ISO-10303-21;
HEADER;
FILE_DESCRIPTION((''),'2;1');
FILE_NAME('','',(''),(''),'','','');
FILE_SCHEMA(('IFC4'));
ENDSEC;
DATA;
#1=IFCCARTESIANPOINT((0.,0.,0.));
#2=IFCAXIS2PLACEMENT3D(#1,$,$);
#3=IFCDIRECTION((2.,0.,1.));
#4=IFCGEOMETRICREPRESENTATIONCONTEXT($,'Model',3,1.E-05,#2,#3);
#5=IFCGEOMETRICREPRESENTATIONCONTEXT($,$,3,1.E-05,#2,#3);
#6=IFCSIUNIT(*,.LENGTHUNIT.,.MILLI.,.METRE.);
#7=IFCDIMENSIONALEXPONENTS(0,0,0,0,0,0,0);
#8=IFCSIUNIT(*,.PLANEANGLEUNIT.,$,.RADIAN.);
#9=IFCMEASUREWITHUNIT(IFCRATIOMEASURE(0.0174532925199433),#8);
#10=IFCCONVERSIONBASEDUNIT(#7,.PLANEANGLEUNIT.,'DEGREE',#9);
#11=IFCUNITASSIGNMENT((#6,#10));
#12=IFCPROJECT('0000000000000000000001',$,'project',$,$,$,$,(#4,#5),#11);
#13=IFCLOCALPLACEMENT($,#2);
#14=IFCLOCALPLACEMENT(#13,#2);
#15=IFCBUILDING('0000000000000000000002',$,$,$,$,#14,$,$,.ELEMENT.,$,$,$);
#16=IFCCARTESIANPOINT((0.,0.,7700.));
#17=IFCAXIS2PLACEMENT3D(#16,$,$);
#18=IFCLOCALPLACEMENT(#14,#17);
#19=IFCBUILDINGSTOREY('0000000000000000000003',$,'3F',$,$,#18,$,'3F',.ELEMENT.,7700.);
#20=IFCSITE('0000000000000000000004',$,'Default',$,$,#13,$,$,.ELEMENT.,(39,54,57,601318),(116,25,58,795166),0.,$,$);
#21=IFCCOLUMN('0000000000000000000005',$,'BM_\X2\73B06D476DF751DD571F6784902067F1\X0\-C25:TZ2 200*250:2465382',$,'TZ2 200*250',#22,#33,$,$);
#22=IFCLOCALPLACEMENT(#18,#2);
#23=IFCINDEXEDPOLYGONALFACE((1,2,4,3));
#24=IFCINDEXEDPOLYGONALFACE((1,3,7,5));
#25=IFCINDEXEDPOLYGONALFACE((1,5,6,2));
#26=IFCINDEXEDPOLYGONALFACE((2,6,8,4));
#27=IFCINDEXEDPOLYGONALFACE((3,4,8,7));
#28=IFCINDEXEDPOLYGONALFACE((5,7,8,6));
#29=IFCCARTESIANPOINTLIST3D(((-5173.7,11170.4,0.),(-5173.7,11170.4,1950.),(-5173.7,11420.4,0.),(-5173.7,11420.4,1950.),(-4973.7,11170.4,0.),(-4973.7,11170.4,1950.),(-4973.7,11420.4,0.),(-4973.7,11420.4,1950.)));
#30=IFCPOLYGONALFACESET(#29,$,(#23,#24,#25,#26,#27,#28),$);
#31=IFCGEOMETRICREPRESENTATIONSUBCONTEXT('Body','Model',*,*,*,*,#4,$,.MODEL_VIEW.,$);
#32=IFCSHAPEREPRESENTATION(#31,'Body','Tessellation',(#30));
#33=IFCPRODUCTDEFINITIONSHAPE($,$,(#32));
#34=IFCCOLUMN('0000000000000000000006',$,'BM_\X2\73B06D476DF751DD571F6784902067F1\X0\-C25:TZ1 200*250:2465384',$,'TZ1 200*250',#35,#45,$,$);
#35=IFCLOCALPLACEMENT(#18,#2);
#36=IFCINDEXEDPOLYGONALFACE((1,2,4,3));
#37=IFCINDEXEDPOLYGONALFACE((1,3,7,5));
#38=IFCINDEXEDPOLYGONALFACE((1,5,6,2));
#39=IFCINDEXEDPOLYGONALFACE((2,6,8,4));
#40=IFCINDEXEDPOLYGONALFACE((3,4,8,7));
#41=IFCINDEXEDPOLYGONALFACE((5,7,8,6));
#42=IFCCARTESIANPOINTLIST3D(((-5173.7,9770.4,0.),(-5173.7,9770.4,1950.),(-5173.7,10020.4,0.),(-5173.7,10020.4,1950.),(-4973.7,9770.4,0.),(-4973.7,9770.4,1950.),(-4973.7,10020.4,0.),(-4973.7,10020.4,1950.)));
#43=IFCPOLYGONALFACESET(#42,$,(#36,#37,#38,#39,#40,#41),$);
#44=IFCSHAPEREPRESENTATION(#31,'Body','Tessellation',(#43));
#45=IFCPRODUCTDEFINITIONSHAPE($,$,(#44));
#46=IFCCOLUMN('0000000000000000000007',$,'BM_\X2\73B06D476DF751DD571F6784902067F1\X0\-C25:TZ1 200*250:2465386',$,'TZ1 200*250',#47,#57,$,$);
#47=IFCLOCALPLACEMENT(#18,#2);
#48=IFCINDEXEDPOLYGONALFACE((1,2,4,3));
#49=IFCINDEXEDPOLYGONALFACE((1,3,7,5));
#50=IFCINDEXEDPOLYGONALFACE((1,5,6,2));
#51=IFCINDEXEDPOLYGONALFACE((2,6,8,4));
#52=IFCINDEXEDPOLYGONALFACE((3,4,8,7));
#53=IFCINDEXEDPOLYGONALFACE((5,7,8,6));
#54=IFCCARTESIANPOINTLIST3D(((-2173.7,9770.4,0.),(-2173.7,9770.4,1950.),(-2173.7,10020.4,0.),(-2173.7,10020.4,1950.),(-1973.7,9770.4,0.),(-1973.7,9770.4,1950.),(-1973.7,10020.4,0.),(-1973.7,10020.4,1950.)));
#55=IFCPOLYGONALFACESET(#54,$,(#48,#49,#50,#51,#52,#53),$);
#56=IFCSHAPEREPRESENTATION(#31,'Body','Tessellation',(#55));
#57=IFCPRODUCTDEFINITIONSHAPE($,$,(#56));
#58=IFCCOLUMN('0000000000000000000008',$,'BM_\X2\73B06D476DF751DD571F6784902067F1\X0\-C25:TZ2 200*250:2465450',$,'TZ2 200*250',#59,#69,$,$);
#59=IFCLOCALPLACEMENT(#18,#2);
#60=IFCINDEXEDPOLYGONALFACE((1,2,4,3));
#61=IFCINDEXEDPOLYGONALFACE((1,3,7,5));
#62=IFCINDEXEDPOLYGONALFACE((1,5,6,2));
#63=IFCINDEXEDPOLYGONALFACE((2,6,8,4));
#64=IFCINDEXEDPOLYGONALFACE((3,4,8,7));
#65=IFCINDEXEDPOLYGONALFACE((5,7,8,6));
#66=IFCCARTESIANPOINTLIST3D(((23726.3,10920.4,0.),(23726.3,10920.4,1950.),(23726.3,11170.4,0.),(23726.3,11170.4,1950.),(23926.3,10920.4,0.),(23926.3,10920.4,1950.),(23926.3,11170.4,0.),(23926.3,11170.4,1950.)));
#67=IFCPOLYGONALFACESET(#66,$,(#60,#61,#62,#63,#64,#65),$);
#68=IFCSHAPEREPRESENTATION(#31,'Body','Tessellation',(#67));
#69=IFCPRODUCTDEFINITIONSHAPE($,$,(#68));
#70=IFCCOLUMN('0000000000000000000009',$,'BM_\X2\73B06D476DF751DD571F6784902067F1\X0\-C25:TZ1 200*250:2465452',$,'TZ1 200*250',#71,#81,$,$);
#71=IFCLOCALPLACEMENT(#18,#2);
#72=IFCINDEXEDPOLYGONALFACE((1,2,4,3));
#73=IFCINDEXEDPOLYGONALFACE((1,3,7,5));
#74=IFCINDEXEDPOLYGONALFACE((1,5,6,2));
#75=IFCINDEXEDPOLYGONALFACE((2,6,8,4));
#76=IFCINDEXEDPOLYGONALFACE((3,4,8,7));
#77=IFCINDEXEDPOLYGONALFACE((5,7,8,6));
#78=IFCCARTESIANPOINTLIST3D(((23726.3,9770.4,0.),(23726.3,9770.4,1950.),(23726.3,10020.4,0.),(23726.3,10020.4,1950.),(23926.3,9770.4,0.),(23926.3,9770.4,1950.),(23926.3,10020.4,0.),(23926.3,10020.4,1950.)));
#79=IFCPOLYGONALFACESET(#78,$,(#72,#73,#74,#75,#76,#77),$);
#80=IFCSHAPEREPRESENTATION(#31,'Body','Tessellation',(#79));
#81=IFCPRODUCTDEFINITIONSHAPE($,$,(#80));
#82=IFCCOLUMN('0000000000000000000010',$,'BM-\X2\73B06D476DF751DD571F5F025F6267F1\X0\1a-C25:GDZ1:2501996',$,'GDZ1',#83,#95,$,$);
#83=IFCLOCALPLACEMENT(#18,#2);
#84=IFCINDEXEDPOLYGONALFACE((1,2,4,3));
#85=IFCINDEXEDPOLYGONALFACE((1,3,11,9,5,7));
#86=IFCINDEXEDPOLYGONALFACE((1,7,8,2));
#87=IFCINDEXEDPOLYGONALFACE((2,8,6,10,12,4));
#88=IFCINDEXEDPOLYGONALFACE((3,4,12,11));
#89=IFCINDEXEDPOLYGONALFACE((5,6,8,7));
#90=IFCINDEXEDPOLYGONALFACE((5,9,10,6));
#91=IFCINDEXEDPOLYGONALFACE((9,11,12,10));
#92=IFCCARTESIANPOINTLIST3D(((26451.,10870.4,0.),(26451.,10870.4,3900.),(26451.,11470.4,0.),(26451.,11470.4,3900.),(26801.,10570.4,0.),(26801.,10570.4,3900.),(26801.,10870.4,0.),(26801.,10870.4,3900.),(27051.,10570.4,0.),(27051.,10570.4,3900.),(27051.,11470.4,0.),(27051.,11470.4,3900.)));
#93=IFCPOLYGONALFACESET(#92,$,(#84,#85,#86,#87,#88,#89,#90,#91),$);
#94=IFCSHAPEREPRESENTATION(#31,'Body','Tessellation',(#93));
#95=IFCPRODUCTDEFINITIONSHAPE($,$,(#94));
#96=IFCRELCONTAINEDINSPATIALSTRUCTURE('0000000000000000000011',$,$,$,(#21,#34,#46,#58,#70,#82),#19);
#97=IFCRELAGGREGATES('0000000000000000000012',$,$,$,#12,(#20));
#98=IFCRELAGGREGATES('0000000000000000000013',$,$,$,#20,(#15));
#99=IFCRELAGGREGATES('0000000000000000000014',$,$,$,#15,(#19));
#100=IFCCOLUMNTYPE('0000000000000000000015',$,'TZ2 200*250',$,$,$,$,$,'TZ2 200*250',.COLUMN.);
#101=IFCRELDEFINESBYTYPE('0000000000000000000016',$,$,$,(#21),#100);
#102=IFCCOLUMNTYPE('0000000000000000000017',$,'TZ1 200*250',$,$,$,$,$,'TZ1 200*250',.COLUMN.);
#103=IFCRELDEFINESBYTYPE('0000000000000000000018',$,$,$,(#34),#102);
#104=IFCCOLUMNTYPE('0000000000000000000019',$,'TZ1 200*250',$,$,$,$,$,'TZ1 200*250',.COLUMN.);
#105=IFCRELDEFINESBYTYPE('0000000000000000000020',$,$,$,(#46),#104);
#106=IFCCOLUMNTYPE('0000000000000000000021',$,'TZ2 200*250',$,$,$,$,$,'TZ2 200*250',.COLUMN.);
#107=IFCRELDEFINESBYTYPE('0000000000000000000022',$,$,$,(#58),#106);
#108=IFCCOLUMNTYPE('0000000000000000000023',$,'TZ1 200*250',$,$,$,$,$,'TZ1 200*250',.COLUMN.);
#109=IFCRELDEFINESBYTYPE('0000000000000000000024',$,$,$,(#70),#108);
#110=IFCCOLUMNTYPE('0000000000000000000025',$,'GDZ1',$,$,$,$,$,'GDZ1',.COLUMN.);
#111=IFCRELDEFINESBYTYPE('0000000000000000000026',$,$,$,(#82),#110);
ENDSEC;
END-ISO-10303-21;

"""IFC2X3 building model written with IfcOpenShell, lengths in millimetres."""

from ifc_helpers import new_model, entity, si_unit, converted_unit, direction, frame, frame_2d, origin, place, context, subcontext, project, spatial, polyline, rectangle, outline, extrude, source, transform, mapped, type_object, type_shapes, element, save


model = new_model("IFC2X3")

# Units and contexts
model_context = context("Model", 3, precision=1e-05, world=origin(), true_north=direction((2.0, 0.0, 1.0)))
context_of_model = context(None, 3, precision=1e-05, world=origin(), true_north=direction((2.0, 0.0, 1.0)))
body_context = subcontext(model_context, "Body", "Model", "MODEL_VIEW")
ifc_project = project(units=[si_unit("LENGTHUNIT", "METRE", prefix="MILLI"), converted_unit("PLANEANGLEUNIT", "DEGREE", entity("IfcRatioMeasure", 0.0174532925199433), si_unit("PLANEANGLEUNIT", "RADIAN"), dimensions=[0, 0, 0, 0, 0, 0, 0])], contexts=[model_context, context_of_model])

# Site, building, storey
site_placement = place(None, origin())
site = spatial("IfcSite", under=ifc_project, at=site_placement, Name="Default", CompositionType="ELEMENT", RefLatitude=(39, 54, 57, 601318), RefLongitude=(116, 25, 58, 795166), RefElevation=0.0)
building_placement = place(site_placement, origin())
building = spatial("IfcBuilding", under=site, at=building_placement, CompositionType="ELEMENT")
storey_placement = place(building_placement, frame((0.0, 0.0, 7700.0)))
storey = spatial("IfcBuildingStorey", under=building, at=storey_placement, Name="3F", LongName="3F", CompositionType="ELEMENT", Elevation=7700.0)

# Columns
column_type_1 = type_object("IfcColumnType", Name="TZ2 200*250", ElementType="TZ2 200*250", PredefinedType="COLUMN")
shared_shape_1 = source(origin(), body_context, "Body", "SweptSolid", [
    extrude(rectangle(XDim=250.0, YDim=200.0, at=frame_2d((-5073.7, 11295.4), x_axis=(0.0, -1.0))), origin(), (0.0, 0.0, 1.0), 1950.0),
])
type_shapes(column_type_1, [shared_shape_1])
column_1_placement = place(storey_placement, origin())
element("IfcColumn", 1, at=column_1_placement, inside=storey, type_object=column_type_1, Name="BM_现浇混凝土构造柱-C25:TZ2 200*250:2465382", ObjectType="TZ2 200*250", context=body_context, shape_type="MappedRepresentation", body=[
    mapped(shared_shape_1, transform((0.0, 0.0, 0.0), scale=1.0)),
])
column_type_2 = type_object("IfcColumnType", Name="TZ1 200*250", ElementType="TZ1 200*250", PredefinedType="COLUMN")
shared_shape_2 = source(origin(), body_context, "Body", "SweptSolid", [
    extrude(rectangle(XDim=250.0, YDim=200.0, at=frame_2d((-5073.7, 9895.4), x_axis=(0.0, -1.0))), origin(), (0.0, 0.0, 1.0), 1950.0),
])
type_shapes(column_type_2, [shared_shape_2])
column_2_placement = place(storey_placement, origin())
element("IfcColumn", 2, at=column_2_placement, inside=storey, type_object=column_type_2, Name="BM_现浇混凝土构造柱-C25:TZ1 200*250:2465384", ObjectType="TZ1 200*250", context=body_context, shape_type="MappedRepresentation", body=[
    mapped(shared_shape_2, transform((0.0, 0.0, 0.0), scale=1.0)),
])
column_type_3 = type_object("IfcColumnType", Name="TZ1 200*250", ElementType="TZ1 200*250", PredefinedType="COLUMN")
shared_shape_3 = source(origin(), body_context, "Body", "SweptSolid", [
    extrude(rectangle(XDim=250.0, YDim=200.0, at=frame_2d((-2073.7, 9895.4), x_axis=(0.0, -1.0))), origin(), (0.0, 0.0, 1.0), 1950.0),
])
type_shapes(column_type_3, [shared_shape_3])
column_3_placement = place(storey_placement, origin())
element("IfcColumn", 3, at=column_3_placement, inside=storey, type_object=column_type_3, Name="BM_现浇混凝土构造柱-C25:TZ1 200*250:2465386", ObjectType="TZ1 200*250", context=body_context, shape_type="MappedRepresentation", body=[
    mapped(shared_shape_3, transform((0.0, 0.0, 0.0), scale=1.0)),
])
column_type_4 = type_object("IfcColumnType", Name="TZ2 200*250", ElementType="TZ2 200*250", PredefinedType="COLUMN")
shared_shape_4 = source(origin(), body_context, "Body", "SweptSolid", [
    extrude(rectangle(XDim=250.0, YDim=200.0, at=frame_2d((23826.3, 11045.4), x_axis=(0.0, -1.0))), origin(), (0.0, 0.0, 1.0), 1950.0),
])
type_shapes(column_type_4, [shared_shape_4])
column_4_placement = place(storey_placement, origin())
element("IfcColumn", 4, at=column_4_placement, inside=storey, type_object=column_type_4, Name="BM_现浇混凝土构造柱-C25:TZ2 200*250:2465450", ObjectType="TZ2 200*250", context=body_context, shape_type="MappedRepresentation", body=[
    mapped(shared_shape_4, transform((0.0, 0.0, 0.0), scale=1.0)),
])
column_type_5 = type_object("IfcColumnType", Name="TZ1 200*250", ElementType="TZ1 200*250", PredefinedType="COLUMN")
shared_shape_5 = source(origin(), body_context, "Body", "SweptSolid", [
    extrude(rectangle(XDim=250.0, YDim=200.0, at=frame_2d((23826.3, 9895.4), x_axis=(0.0, -1.0))), origin(), (0.0, 0.0, 1.0), 1950.0),
])
type_shapes(column_type_5, [shared_shape_5])
column_5_placement = place(storey_placement, origin())
element("IfcColumn", 5, at=column_5_placement, inside=storey, type_object=column_type_5, Name="BM_现浇混凝土构造柱-C25:TZ1 200*250:2465452", ObjectType="TZ1 200*250", context=body_context, shape_type="MappedRepresentation", body=[
    mapped(shared_shape_5, transform((0.0, 0.0, 0.0), scale=1.0)),
])
column_type_6 = type_object("IfcColumnType", Name="GDZ1", ElementType="GDZ1", PredefinedType="COLUMN")
shared_shape_6 = source(origin(), body_context, "Body", "SweptSolid", [
    extrude(outline(polyline([(27051.0, 10570.4), (27051.0, 11470.4), (26451.0, 11470.4), (26451.0, 10870.4), (26801.0, 10870.4), (26801.0, 10570.4), (27051.0, 10570.4)])), origin(), (0.0, 0.0, 1.0), 3900.0),
])
type_shapes(column_type_6, [shared_shape_6])
column_6_placement = place(storey_placement, origin())
element("IfcColumn", 6, at=column_6_placement, inside=storey, type_object=column_type_6, Name="BM-现浇混凝土异形柱1a-C25:GDZ1:2501996", ObjectType="GDZ1", context=body_context, shape_type="MappedRepresentation", body=[
    mapped(shared_shape_6, transform((0.0, 0.0, 0.0), scale=1.0)),
])

save(model, "model.ifc")
